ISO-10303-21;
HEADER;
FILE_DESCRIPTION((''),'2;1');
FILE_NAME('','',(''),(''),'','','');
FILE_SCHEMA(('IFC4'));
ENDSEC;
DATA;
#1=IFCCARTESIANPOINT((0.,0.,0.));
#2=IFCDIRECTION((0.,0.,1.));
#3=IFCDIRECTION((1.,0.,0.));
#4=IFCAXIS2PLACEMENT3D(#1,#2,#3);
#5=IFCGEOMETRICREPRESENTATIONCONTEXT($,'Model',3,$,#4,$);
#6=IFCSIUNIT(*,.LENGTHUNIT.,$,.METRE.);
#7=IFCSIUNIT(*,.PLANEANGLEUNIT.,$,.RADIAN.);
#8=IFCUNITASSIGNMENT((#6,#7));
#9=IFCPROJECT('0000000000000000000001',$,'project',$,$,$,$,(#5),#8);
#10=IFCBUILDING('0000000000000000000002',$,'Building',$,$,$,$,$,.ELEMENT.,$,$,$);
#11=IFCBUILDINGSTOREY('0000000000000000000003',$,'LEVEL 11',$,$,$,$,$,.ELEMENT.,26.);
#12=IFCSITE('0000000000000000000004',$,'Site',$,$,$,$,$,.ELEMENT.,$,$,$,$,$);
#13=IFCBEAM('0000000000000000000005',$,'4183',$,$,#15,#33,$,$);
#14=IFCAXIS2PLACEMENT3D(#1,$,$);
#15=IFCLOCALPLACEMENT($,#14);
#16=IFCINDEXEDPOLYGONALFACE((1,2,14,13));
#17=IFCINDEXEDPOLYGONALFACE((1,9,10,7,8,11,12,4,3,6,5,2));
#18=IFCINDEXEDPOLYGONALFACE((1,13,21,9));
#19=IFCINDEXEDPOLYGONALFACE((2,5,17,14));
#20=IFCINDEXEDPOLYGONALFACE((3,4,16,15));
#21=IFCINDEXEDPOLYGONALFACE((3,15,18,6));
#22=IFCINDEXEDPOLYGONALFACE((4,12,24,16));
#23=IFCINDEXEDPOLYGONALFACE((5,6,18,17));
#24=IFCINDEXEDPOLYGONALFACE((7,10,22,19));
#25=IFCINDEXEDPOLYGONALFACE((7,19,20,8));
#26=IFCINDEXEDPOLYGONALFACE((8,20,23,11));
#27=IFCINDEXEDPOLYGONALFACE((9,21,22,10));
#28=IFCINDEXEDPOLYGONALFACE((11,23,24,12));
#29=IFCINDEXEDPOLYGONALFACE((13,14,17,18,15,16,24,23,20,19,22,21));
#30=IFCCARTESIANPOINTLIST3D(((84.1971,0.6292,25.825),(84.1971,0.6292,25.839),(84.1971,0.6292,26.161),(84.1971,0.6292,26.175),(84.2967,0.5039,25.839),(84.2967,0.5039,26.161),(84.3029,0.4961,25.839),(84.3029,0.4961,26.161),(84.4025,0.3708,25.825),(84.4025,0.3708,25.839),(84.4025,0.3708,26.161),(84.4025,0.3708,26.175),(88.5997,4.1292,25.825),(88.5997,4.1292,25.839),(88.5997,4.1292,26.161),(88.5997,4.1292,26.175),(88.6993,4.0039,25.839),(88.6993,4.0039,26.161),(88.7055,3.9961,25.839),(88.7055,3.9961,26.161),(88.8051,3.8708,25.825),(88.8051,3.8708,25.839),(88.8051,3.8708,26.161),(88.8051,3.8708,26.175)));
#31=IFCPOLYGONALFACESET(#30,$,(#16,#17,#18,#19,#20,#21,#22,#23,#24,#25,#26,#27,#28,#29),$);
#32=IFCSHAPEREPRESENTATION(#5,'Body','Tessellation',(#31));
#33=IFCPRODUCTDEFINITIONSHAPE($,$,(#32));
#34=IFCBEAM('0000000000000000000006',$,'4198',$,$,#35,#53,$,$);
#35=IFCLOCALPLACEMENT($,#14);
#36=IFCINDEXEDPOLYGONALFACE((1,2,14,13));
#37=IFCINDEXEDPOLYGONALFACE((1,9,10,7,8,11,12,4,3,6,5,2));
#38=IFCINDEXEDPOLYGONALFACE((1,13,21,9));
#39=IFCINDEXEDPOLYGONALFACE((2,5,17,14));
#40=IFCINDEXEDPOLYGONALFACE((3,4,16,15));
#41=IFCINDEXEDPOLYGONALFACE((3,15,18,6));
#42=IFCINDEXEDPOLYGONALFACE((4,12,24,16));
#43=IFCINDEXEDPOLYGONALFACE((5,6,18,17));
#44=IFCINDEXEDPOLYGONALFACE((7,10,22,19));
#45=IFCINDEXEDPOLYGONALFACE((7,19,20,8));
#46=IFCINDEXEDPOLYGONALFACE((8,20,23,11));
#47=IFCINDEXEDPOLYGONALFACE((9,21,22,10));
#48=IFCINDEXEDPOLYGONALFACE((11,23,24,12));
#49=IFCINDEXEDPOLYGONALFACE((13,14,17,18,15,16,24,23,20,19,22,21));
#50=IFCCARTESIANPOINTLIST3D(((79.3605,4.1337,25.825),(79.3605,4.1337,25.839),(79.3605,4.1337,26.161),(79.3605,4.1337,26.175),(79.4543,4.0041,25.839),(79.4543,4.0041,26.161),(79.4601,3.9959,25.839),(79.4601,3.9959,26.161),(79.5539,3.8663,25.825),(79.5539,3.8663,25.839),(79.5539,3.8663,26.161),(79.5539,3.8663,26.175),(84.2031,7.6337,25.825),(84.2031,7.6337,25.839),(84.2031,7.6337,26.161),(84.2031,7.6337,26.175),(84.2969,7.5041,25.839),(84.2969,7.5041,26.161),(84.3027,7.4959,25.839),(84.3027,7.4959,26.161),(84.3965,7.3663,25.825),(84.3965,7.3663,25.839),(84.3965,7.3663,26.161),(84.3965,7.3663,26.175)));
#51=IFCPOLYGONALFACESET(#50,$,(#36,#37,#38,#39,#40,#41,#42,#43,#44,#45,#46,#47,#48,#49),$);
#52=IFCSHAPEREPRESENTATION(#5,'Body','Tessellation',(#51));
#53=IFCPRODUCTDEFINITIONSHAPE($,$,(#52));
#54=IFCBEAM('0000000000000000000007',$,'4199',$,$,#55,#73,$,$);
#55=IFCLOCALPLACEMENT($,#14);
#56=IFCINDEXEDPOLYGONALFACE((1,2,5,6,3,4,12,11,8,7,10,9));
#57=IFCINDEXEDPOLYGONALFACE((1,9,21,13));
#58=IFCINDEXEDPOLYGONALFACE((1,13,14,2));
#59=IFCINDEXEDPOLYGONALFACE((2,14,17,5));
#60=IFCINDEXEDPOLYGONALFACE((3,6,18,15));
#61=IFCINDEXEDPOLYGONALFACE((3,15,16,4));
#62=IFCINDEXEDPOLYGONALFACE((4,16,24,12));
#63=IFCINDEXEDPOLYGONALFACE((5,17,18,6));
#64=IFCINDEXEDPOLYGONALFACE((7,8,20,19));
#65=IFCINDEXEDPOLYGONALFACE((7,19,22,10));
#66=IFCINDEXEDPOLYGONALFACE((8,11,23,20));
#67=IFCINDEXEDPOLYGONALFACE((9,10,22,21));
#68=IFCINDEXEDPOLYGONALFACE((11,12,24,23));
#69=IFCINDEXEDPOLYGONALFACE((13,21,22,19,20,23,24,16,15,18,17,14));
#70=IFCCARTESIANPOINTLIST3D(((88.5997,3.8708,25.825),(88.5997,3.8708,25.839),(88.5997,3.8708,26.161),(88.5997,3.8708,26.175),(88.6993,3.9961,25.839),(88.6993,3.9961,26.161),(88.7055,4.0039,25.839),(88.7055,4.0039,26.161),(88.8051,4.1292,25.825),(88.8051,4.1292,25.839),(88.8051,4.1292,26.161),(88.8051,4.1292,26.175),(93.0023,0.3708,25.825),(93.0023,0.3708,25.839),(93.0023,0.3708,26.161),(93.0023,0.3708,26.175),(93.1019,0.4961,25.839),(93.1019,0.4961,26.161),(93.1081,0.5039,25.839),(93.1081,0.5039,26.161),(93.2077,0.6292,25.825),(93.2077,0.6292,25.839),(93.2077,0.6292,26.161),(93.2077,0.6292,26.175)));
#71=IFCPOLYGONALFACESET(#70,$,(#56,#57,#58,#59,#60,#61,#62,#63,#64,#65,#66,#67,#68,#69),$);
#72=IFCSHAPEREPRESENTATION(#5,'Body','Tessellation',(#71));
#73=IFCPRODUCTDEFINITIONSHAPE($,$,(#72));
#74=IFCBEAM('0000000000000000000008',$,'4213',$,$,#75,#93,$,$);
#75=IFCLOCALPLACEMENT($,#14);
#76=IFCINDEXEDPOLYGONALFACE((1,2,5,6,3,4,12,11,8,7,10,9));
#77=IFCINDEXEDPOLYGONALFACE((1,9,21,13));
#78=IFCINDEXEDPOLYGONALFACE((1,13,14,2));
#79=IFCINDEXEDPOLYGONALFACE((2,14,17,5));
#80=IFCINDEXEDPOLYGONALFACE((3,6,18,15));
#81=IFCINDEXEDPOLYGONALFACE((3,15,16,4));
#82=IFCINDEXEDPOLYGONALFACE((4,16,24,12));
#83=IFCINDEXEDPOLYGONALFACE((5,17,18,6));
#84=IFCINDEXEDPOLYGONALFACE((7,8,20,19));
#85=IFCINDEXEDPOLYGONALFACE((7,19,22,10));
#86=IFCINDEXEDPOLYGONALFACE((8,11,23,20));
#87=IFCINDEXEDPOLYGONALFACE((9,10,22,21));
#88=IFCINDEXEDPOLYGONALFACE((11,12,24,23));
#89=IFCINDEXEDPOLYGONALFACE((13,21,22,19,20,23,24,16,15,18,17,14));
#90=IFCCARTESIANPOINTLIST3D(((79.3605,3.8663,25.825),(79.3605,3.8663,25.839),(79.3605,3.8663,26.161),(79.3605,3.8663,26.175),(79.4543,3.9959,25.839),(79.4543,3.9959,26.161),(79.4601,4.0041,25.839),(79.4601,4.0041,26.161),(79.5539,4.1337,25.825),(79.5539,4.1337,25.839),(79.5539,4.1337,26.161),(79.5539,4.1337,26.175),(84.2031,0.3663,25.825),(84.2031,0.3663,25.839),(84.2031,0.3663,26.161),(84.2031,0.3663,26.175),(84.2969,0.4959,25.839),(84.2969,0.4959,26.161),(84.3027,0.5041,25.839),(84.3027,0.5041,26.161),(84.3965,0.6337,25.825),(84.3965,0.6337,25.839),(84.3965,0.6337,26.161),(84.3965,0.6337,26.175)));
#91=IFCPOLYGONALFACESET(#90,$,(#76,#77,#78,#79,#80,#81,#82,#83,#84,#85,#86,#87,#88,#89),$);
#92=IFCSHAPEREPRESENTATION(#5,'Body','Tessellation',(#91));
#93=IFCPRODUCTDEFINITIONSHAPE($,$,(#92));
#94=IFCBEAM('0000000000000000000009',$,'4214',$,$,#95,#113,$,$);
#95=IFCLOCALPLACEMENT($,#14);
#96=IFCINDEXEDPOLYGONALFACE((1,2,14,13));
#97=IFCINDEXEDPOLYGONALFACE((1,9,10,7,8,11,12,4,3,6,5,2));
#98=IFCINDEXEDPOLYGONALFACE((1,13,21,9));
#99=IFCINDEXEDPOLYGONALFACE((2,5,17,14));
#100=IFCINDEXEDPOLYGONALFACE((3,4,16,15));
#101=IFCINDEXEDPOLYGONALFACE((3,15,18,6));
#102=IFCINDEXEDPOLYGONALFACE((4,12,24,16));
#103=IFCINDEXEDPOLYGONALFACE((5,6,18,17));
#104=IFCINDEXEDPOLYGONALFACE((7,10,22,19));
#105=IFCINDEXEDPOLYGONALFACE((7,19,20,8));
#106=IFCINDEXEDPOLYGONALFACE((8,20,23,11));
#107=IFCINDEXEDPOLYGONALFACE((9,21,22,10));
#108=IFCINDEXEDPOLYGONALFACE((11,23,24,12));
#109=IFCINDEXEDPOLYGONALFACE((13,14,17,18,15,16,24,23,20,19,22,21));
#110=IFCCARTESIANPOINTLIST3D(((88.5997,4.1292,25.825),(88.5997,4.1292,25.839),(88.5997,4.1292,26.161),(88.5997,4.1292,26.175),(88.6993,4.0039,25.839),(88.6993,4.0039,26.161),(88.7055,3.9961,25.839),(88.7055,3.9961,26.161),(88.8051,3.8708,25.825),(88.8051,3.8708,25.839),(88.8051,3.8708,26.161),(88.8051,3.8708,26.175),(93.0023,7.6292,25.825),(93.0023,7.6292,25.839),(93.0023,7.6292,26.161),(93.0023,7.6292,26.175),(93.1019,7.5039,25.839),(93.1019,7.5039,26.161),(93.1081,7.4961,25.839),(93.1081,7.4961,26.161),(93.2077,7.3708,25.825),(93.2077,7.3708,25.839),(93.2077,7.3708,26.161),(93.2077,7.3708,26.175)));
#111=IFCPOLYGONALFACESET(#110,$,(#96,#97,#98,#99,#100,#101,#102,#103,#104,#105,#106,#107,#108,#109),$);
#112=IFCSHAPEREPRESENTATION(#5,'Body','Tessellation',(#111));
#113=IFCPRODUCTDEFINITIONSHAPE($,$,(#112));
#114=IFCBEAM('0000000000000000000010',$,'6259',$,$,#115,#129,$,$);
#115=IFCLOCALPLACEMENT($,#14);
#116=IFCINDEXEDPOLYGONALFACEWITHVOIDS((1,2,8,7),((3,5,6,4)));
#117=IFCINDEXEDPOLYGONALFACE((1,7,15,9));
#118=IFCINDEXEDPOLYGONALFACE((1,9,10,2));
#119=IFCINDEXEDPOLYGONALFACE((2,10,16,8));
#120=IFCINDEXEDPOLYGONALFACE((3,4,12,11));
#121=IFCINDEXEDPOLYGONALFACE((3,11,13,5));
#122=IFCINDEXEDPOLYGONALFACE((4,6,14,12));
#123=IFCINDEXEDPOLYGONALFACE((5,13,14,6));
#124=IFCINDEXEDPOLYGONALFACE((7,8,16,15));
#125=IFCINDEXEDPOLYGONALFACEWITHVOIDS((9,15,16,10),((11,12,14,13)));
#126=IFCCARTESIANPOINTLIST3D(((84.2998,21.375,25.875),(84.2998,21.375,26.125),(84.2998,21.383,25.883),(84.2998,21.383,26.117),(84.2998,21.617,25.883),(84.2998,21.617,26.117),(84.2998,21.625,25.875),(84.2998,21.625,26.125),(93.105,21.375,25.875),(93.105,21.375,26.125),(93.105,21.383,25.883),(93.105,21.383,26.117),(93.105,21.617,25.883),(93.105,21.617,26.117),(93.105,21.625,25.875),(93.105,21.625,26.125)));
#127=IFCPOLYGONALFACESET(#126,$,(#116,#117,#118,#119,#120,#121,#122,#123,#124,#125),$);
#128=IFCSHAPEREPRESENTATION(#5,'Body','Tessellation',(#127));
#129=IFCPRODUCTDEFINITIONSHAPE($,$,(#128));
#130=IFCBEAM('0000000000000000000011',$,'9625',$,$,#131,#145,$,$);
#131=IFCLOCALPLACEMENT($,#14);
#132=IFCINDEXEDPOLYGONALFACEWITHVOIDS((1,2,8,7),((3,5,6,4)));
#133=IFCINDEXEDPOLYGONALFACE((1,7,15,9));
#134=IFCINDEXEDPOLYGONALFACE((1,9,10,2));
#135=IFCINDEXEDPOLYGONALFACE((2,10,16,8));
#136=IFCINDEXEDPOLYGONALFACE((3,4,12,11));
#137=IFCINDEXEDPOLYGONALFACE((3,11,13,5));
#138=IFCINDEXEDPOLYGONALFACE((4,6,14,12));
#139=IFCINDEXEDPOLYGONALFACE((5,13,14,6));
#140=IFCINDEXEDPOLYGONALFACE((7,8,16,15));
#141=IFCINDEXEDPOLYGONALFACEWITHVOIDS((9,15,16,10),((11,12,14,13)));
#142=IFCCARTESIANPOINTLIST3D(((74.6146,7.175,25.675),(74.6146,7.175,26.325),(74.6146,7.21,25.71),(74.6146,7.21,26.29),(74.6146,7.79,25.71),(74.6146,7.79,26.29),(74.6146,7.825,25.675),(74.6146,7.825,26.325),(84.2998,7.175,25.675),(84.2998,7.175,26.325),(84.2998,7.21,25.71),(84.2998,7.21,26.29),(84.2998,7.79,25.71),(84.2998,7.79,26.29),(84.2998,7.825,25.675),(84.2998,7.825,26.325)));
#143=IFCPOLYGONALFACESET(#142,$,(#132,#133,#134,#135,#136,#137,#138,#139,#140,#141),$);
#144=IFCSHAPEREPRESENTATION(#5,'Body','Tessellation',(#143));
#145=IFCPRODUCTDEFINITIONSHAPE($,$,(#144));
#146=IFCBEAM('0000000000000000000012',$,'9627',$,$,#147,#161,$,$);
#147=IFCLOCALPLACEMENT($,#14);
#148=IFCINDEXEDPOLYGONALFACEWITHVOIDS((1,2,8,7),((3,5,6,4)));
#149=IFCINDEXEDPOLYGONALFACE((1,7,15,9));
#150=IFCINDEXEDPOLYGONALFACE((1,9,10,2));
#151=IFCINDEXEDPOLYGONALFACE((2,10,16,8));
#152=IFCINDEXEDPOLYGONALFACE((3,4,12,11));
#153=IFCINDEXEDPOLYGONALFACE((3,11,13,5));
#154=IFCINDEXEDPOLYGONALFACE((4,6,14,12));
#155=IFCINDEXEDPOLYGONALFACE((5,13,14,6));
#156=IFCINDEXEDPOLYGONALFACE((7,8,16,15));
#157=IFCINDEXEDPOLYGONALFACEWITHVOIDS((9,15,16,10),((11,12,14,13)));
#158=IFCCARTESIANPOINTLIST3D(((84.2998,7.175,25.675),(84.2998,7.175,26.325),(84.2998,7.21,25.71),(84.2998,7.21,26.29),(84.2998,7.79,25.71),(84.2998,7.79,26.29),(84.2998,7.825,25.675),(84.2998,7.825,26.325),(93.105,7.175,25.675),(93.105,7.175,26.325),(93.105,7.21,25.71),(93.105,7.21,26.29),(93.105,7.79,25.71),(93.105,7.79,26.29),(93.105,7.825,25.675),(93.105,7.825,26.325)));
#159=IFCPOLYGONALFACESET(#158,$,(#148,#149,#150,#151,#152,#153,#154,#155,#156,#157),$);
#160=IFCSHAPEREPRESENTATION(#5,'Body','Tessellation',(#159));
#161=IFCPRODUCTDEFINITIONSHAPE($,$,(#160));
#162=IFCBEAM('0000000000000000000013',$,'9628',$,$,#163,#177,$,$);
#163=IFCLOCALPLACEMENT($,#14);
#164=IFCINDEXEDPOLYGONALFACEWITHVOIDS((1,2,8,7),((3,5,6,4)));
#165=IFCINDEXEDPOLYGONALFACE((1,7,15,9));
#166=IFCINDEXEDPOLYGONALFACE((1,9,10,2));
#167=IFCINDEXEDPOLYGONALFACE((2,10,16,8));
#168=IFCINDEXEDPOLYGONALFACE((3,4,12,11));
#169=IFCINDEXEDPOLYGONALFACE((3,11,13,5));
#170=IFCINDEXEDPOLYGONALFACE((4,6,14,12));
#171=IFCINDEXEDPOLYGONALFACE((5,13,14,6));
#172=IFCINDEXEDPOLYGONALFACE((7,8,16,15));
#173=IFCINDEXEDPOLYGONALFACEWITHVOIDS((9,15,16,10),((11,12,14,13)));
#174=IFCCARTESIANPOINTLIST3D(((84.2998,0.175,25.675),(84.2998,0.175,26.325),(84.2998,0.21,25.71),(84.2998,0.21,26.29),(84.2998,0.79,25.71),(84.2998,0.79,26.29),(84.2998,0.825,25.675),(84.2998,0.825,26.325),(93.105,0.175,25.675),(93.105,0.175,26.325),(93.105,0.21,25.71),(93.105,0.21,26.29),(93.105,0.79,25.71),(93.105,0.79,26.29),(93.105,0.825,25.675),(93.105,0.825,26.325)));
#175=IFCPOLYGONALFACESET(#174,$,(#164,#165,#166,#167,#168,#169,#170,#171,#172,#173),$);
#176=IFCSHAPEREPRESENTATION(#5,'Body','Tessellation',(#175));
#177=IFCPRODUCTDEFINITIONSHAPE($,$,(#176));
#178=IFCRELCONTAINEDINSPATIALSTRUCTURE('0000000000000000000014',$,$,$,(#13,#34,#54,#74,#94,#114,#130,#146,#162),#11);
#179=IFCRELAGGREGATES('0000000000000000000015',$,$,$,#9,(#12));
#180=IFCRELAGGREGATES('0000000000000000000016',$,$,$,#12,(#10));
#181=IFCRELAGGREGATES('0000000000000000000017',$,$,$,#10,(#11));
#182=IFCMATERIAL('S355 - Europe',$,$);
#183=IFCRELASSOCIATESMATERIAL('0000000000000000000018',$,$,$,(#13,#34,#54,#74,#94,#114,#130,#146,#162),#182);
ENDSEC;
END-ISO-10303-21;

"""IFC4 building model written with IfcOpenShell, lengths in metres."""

from ifc_helpers import new_model, si_unit, frame, origin_with_axes, origin_2d_with_axis, place, context, project, spatial, hollow_rectangle, i_section, extrude, material, material_profile, profile_set, profile_usage, element, save


model = new_model("IFC4")

# Units and contexts
model_context = context("Model", 3, world=origin_with_axes())
ifc_project = project(units=[si_unit("LENGTHUNIT", "METRE"), si_unit("PLANEANGLEUNIT", "RADIAN")], contexts=[model_context])

# Site, building, storey
site = spatial("IfcSite", under=ifc_project, Name="Site", CompositionType="ELEMENT")
building = spatial("IfcBuilding", under=site, Name="Building", CompositionType="ELEMENT")
storey = spatial("IfcBuildingStorey", under=building, Name="LEVEL 11", CompositionType="ELEMENT", Elevation=26.0)

# Shared definitions
ifc_material = material(Name="S355 - Europe")

# Beams
ifc_material_profile_1 = material_profile(ifc_material, i_section(OverallWidth=0.33, OverallDepth=0.35, WebThickness=0.01, FlangeThickness=0.014, at=origin_2d_with_axis()))
ifc_profile_set_1 = profile_set([ifc_material_profile_1])
ifc_profile_usage_1 = profile_usage(ifc_profile_set_1, cardinal=10)
beam_1_placement = place(None, frame((84.2998, 0.5, 26.0), z_axis=(0.78278, 0.622298, 0.0), x_axis=(-0.622298, 0.78278, 0.0)))
element("IfcBeam", 1, at=beam_1_placement, inside=storey, material=ifc_profile_usage_1, Name="4183", context=model_context, shape_type="SweptSolid", body=[
    extrude(i_section(OverallWidth=0.33, OverallDepth=0.35, WebThickness=0.01, FlangeThickness=0.014, at=origin_2d_with_axis()), origin_with_axes(), (0.0, 0.0, 1.0), 5.6243),
])
ifc_material_profile_2 = material_profile(ifc_material, i_section(OverallWidth=0.33, OverallDepth=0.35, WebThickness=0.01, FlangeThickness=0.014, at=origin_2d_with_axis()))
ifc_profile_set_2 = profile_set([ifc_material_profile_2])
ifc_profile_usage_2 = profile_usage(ifc_profile_set_2, cardinal=10)
beam_2_placement = place(None, frame((79.4572, 4.0, 26.0), z_axis=(0.810475, 0.585773, 0.0), x_axis=(-0.585773, 0.810475, 0.0)))
element("IfcBeam", 2, at=beam_2_placement, inside=storey, material=ifc_profile_usage_2, Name="4198", context=model_context, shape_type="SweptSolid", body=[
    extrude(i_section(OverallWidth=0.33, OverallDepth=0.35, WebThickness=0.01, FlangeThickness=0.014, at=origin_2d_with_axis()), origin_with_axes(), (0.0, 0.0, 1.0), 5.975),
])
ifc_material_profile_3 = material_profile(ifc_material, i_section(OverallWidth=0.33, OverallDepth=0.35, WebThickness=0.01, FlangeThickness=0.014, at=origin_2d_with_axis()))
ifc_profile_set_3 = profile_set([ifc_material_profile_3])
ifc_profile_usage_3 = profile_usage(ifc_profile_set_3, cardinal=10)
beam_3_placement = place(None, frame((88.7024, 4.0, 26.0), z_axis=(0.78278, -0.622298, 0.0), x_axis=(0.622298, 0.78278, 0.0)))
element("IfcBeam", 3, at=beam_3_placement, inside=storey, material=ifc_profile_usage_3, Name="4199", context=model_context, shape_type="SweptSolid", body=[
    extrude(i_section(OverallWidth=0.33, OverallDepth=0.35, WebThickness=0.01, FlangeThickness=0.014, at=origin_2d_with_axis()), origin_with_axes(), (0.0, 0.0, 1.0), 5.6243),
])
ifc_material_profile_4 = material_profile(ifc_material, i_section(OverallWidth=0.33, OverallDepth=0.35, WebThickness=0.01, FlangeThickness=0.014, at=origin_2d_with_axis()))
ifc_profile_set_4 = profile_set([ifc_material_profile_4])
ifc_profile_usage_4 = profile_usage(ifc_profile_set_4, cardinal=10)
beam_4_placement = place(None, frame((79.4572, 4.0, 26.0), z_axis=(0.810475, -0.585773, 0.0), x_axis=(0.585773, 0.810475, 0.0)))
element("IfcBeam", 4, at=beam_4_placement, inside=storey, material=ifc_profile_usage_4, Name="4213", context=model_context, shape_type="SweptSolid", body=[
    extrude(i_section(OverallWidth=0.33, OverallDepth=0.35, WebThickness=0.01, FlangeThickness=0.014, at=origin_2d_with_axis()), origin_with_axes(), (0.0, 0.0, 1.0), 5.975),
])
ifc_material_profile_5 = material_profile(ifc_material, i_section(OverallWidth=0.33, OverallDepth=0.35, WebThickness=0.01, FlangeThickness=0.014, at=origin_2d_with_axis()))
ifc_profile_set_5 = profile_set([ifc_material_profile_5])
ifc_profile_usage_5 = profile_usage(ifc_profile_set_5, cardinal=10)
beam_5_placement = place(None, frame((88.7024, 4.0, 26.0), z_axis=(0.78278, 0.622298, 0.0), x_axis=(-0.622298, 0.78278, 0.0)))
element("IfcBeam", 5, at=beam_5_placement, inside=storey, material=ifc_profile_usage_5, Name="4214", context=model_context, shape_type="SweptSolid", body=[
    extrude(i_section(OverallWidth=0.33, OverallDepth=0.35, WebThickness=0.01, FlangeThickness=0.014, at=origin_2d_with_axis()), origin_with_axes(), (0.0, 0.0, 1.0), 5.6243),
])
ifc_material_profile_6 = material_profile(ifc_material, hollow_rectangle(XDim=0.25, YDim=0.25, WallThickness=0.008, at=origin_2d_with_axis()))
ifc_profile_set_6 = profile_set([ifc_material_profile_6])
ifc_profile_usage_6 = profile_usage(ifc_profile_set_6, cardinal=10)
beam_6_placement = place(None, frame((84.2998, 21.5, 26.0), z_axis=(1.0, 0.0, 0.0), x_axis=(0.0, 1.0, 0.0)))
element("IfcBeam", 6, at=beam_6_placement, inside=storey, material=ifc_profile_usage_6, Name="6259", context=model_context, shape_type="SweptSolid", body=[
    extrude(hollow_rectangle(XDim=0.25, YDim=0.25, WallThickness=0.008, at=origin_2d_with_axis()), origin_with_axes(), (0.0, 0.0, 1.0), 8.8052),
])
ifc_material_profile_7 = material_profile(ifc_material, hollow_rectangle(XDim=0.65, YDim=0.65, WallThickness=0.035, at=origin_2d_with_axis()))
ifc_profile_set_7 = profile_set([ifc_material_profile_7])
ifc_profile_usage_7 = profile_usage(ifc_profile_set_7, cardinal=10)
beam_7_placement = place(None, frame((84.2998, 7.5, 26.0), z_axis=(-1.0, 0.0, 0.0), x_axis=(0.0, -1.0, 0.0)))
element("IfcBeam", 7, at=beam_7_placement, inside=storey, material=ifc_profile_usage_7, Name="9625", context=model_context, shape_type="SweptSolid", body=[
    extrude(hollow_rectangle(XDim=0.65, YDim=0.65, WallThickness=0.035, at=origin_2d_with_axis()), origin_with_axes(), (0.0, 0.0, 1.0), 9.6852),
])
ifc_material_profile_8 = material_profile(ifc_material, hollow_rectangle(XDim=0.65, YDim=0.65, WallThickness=0.035, at=origin_2d_with_axis()))
ifc_profile_set_8 = profile_set([ifc_material_profile_8])
ifc_profile_usage_8 = profile_usage(ifc_profile_set_8, cardinal=10)
beam_8_placement = place(None, frame((84.2998, 7.5, 26.0), z_axis=(1.0, 0.0, 0.0), x_axis=(0.0, 1.0, 0.0)))
element("IfcBeam", 8, at=beam_8_placement, inside=storey, material=ifc_profile_usage_8, Name="9627", context=model_context, shape_type="SweptSolid", body=[
    extrude(hollow_rectangle(XDim=0.65, YDim=0.65, WallThickness=0.035, at=origin_2d_with_axis()), origin_with_axes(), (0.0, 0.0, 1.0), 8.8052),
])
ifc_material_profile_9 = material_profile(ifc_material, hollow_rectangle(XDim=0.65, YDim=0.65, WallThickness=0.035, at=origin_2d_with_axis()))
ifc_profile_set_9 = profile_set([ifc_material_profile_9])
ifc_profile_usage_9 = profile_usage(ifc_profile_set_9, cardinal=10)
beam_9_placement = place(None, frame((84.2998, 0.5, 26.0), z_axis=(1.0, 0.0, 0.0), x_axis=(0.0, 1.0, 0.0)))
element("IfcBeam", 9, at=beam_9_placement, inside=storey, material=ifc_profile_usage_9, Name="9628", context=model_context, shape_type="SweptSolid", body=[
    extrude(hollow_rectangle(XDim=0.65, YDim=0.65, WallThickness=0.035, at=origin_2d_with_axis()), origin_with_axes(), (0.0, 0.0, 1.0), 8.8052),
])

save(model, "model.ifc")
